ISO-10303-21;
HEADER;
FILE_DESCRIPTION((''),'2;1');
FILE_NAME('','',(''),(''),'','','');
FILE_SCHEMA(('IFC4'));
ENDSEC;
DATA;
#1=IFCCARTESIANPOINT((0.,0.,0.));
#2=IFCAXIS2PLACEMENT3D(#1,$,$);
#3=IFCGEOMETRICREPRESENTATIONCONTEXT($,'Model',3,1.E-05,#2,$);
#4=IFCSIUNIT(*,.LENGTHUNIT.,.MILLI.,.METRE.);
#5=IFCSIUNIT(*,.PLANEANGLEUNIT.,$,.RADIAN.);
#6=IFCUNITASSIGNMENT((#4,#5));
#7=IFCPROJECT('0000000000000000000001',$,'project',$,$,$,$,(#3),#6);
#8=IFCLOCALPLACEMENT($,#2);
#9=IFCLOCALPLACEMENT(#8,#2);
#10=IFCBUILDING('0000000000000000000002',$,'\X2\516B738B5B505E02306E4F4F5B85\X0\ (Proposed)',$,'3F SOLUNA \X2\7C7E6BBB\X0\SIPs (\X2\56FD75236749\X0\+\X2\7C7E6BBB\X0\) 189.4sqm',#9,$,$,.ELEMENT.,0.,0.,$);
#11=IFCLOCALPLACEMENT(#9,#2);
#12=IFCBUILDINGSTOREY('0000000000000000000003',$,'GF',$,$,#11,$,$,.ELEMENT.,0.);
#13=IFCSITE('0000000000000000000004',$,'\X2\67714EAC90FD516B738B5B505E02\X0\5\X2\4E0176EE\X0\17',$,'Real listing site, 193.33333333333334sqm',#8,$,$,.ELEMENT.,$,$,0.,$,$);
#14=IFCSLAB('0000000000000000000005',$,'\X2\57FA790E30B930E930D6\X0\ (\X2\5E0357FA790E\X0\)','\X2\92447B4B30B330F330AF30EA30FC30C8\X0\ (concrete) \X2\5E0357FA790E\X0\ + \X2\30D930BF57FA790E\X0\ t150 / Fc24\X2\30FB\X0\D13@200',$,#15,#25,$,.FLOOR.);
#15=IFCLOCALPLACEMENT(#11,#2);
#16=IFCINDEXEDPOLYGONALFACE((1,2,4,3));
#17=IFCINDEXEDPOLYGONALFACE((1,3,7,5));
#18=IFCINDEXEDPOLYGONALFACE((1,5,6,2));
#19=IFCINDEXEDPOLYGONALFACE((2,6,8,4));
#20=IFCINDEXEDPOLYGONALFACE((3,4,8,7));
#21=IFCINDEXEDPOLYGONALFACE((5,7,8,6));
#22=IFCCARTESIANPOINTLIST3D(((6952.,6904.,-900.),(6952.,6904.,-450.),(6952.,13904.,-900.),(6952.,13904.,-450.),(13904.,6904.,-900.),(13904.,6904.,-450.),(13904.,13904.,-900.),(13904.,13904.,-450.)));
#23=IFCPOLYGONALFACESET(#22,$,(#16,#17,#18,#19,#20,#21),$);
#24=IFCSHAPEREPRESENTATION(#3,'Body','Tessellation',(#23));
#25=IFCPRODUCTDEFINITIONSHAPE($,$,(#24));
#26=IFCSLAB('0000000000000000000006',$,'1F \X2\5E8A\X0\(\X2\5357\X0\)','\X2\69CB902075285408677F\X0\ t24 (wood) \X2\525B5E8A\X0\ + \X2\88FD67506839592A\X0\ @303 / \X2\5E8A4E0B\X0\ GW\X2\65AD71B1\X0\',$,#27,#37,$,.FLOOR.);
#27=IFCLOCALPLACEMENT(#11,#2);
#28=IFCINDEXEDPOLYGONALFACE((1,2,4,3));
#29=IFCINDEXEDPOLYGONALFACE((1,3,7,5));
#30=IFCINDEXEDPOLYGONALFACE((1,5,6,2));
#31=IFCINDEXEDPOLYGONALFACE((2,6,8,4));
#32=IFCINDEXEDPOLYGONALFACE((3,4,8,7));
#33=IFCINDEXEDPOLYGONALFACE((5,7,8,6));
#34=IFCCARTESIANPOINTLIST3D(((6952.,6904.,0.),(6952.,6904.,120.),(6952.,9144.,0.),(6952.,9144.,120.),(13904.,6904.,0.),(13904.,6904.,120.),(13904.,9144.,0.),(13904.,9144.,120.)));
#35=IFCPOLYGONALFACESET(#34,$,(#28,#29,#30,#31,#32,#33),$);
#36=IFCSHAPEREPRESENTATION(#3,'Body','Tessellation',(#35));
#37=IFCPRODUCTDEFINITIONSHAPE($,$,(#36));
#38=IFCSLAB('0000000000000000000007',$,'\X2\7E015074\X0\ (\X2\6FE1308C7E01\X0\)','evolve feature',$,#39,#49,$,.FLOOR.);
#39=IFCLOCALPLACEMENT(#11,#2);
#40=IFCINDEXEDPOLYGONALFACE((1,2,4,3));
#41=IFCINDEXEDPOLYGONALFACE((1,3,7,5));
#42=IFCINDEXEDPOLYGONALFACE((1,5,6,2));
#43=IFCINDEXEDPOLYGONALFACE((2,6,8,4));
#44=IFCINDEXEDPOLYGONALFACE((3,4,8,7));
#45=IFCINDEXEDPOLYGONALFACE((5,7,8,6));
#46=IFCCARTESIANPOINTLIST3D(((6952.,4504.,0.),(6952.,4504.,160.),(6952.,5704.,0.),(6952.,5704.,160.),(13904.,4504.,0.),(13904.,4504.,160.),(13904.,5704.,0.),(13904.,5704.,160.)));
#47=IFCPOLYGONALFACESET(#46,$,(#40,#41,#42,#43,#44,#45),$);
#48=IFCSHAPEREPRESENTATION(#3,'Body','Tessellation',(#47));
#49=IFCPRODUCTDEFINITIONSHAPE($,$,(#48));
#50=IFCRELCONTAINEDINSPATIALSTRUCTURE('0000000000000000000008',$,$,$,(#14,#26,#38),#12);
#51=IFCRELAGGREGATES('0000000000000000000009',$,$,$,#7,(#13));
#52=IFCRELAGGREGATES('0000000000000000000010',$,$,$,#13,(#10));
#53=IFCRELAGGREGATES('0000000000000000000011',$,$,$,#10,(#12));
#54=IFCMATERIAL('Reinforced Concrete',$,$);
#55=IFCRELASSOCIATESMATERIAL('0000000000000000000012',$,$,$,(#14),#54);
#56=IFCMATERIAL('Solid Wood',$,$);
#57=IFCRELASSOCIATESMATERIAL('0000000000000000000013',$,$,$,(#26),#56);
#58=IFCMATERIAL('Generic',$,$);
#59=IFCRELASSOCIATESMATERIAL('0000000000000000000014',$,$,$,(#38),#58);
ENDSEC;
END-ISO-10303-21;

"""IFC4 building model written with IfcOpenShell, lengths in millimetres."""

from ifc_helpers import new_model, si_unit, frame, frame_2d, origin, place, context, project, spatial, rectangle, extrude, material, element, save


model = new_model("IFC4")

# Units and contexts
model_context = context("Model", 3, precision=1e-05, world=origin())
ifc_project = project(units=[si_unit("LENGTHUNIT", "METRE", prefix="MILLI"), si_unit("PLANEANGLEUNIT", "RADIAN")], contexts=[model_context])

# Site, building, storey
site_placement = place(None, origin())
site = spatial("IfcSite", under=ifc_project, at=site_placement, Name="東京都八王子市5丁目17", ObjectType="Real listing site, 193.33333333333334sqm", CompositionType="ELEMENT", RefElevation=0.0)
building_placement = place(site_placement, origin())
building = spatial("IfcBuilding", under=site, at=building_placement, Name="八王子市の住宅 (Proposed)", ObjectType="3F SOLUNA 籾殻SIPs (国産杉+籾殻) 189.4sqm", CompositionType="ELEMENT", ElevationOfRefHeight=0.0, ElevationOfTerrain=0.0)
storey_placement = place(building_placement, origin())
storey = spatial("IfcBuildingStorey", under=building, at=storey_placement, Name="GF", CompositionType="ELEMENT", Elevation=0.0)

# Slabs
ifc_material_1 = material(Name="Reinforced Concrete")
slab_1_placement = place(storey_placement, frame((3476.0, 3452.0, -450.0)))
element("IfcSlab", 1, at=slab_1_placement, inside=storey, material=ifc_material_1, Name="基礎スラブ (布基礎)", Description="鉄筋コンクリート (concrete) 布基礎 + ベタ基礎 t150 / Fc24・D13@200", PredefinedType="FLOOR", context=model_context, shape_type="SweptSolid", body=[
    extrude(rectangle(XDim=6952.0, YDim=7000.0, at=frame_2d((3476.0, 3500.0))), frame((3476.0, 3452.0, -450.0)), (0.0, 0.0, 1.0), 450.0),
])
ifc_material_2 = material(Name="Solid Wood")
slab_2_placement = place(storey_placement, frame((3476.0, 3452.0, 0.0)))
element("IfcSlab", 2, at=slab_2_placement, inside=storey, material=ifc_material_2, Name="1F 床(南)", Description="構造用合板 t24 (wood) 剛床 + 製材根太 @303 / 床下 GW断熱", PredefinedType="FLOOR", context=model_context, shape_type="SweptSolid", body=[
    extrude(rectangle(XDim=6952.0, YDim=2240.0, at=frame_2d((3476.0, 1120.0))), frame((3476.0, 3452.0, 0.0)), (0.0, 0.0, 1.0), 120.0),
])
ifc_material_3 = material(Name="Generic")
slab_3_placement = place(storey_placement, frame((3476.0, 2252.0, 0.0)))
element("IfcSlab", 3, at=slab_3_placement, inside=storey, material=ifc_material_3, Name="縁側 (濡れ縁)", Description="evolve feature", PredefinedType="FLOOR", context=model_context, shape_type="SweptSolid", body=[
    extrude(rectangle(XDim=6952.0, YDim=1200.0, at=frame_2d((3476.0, 600.0))), frame((3476.0, 2252.0, 0.0)), (0.0, 0.0, 1.0), 160.0),
])

save(model, "model.ifc")
